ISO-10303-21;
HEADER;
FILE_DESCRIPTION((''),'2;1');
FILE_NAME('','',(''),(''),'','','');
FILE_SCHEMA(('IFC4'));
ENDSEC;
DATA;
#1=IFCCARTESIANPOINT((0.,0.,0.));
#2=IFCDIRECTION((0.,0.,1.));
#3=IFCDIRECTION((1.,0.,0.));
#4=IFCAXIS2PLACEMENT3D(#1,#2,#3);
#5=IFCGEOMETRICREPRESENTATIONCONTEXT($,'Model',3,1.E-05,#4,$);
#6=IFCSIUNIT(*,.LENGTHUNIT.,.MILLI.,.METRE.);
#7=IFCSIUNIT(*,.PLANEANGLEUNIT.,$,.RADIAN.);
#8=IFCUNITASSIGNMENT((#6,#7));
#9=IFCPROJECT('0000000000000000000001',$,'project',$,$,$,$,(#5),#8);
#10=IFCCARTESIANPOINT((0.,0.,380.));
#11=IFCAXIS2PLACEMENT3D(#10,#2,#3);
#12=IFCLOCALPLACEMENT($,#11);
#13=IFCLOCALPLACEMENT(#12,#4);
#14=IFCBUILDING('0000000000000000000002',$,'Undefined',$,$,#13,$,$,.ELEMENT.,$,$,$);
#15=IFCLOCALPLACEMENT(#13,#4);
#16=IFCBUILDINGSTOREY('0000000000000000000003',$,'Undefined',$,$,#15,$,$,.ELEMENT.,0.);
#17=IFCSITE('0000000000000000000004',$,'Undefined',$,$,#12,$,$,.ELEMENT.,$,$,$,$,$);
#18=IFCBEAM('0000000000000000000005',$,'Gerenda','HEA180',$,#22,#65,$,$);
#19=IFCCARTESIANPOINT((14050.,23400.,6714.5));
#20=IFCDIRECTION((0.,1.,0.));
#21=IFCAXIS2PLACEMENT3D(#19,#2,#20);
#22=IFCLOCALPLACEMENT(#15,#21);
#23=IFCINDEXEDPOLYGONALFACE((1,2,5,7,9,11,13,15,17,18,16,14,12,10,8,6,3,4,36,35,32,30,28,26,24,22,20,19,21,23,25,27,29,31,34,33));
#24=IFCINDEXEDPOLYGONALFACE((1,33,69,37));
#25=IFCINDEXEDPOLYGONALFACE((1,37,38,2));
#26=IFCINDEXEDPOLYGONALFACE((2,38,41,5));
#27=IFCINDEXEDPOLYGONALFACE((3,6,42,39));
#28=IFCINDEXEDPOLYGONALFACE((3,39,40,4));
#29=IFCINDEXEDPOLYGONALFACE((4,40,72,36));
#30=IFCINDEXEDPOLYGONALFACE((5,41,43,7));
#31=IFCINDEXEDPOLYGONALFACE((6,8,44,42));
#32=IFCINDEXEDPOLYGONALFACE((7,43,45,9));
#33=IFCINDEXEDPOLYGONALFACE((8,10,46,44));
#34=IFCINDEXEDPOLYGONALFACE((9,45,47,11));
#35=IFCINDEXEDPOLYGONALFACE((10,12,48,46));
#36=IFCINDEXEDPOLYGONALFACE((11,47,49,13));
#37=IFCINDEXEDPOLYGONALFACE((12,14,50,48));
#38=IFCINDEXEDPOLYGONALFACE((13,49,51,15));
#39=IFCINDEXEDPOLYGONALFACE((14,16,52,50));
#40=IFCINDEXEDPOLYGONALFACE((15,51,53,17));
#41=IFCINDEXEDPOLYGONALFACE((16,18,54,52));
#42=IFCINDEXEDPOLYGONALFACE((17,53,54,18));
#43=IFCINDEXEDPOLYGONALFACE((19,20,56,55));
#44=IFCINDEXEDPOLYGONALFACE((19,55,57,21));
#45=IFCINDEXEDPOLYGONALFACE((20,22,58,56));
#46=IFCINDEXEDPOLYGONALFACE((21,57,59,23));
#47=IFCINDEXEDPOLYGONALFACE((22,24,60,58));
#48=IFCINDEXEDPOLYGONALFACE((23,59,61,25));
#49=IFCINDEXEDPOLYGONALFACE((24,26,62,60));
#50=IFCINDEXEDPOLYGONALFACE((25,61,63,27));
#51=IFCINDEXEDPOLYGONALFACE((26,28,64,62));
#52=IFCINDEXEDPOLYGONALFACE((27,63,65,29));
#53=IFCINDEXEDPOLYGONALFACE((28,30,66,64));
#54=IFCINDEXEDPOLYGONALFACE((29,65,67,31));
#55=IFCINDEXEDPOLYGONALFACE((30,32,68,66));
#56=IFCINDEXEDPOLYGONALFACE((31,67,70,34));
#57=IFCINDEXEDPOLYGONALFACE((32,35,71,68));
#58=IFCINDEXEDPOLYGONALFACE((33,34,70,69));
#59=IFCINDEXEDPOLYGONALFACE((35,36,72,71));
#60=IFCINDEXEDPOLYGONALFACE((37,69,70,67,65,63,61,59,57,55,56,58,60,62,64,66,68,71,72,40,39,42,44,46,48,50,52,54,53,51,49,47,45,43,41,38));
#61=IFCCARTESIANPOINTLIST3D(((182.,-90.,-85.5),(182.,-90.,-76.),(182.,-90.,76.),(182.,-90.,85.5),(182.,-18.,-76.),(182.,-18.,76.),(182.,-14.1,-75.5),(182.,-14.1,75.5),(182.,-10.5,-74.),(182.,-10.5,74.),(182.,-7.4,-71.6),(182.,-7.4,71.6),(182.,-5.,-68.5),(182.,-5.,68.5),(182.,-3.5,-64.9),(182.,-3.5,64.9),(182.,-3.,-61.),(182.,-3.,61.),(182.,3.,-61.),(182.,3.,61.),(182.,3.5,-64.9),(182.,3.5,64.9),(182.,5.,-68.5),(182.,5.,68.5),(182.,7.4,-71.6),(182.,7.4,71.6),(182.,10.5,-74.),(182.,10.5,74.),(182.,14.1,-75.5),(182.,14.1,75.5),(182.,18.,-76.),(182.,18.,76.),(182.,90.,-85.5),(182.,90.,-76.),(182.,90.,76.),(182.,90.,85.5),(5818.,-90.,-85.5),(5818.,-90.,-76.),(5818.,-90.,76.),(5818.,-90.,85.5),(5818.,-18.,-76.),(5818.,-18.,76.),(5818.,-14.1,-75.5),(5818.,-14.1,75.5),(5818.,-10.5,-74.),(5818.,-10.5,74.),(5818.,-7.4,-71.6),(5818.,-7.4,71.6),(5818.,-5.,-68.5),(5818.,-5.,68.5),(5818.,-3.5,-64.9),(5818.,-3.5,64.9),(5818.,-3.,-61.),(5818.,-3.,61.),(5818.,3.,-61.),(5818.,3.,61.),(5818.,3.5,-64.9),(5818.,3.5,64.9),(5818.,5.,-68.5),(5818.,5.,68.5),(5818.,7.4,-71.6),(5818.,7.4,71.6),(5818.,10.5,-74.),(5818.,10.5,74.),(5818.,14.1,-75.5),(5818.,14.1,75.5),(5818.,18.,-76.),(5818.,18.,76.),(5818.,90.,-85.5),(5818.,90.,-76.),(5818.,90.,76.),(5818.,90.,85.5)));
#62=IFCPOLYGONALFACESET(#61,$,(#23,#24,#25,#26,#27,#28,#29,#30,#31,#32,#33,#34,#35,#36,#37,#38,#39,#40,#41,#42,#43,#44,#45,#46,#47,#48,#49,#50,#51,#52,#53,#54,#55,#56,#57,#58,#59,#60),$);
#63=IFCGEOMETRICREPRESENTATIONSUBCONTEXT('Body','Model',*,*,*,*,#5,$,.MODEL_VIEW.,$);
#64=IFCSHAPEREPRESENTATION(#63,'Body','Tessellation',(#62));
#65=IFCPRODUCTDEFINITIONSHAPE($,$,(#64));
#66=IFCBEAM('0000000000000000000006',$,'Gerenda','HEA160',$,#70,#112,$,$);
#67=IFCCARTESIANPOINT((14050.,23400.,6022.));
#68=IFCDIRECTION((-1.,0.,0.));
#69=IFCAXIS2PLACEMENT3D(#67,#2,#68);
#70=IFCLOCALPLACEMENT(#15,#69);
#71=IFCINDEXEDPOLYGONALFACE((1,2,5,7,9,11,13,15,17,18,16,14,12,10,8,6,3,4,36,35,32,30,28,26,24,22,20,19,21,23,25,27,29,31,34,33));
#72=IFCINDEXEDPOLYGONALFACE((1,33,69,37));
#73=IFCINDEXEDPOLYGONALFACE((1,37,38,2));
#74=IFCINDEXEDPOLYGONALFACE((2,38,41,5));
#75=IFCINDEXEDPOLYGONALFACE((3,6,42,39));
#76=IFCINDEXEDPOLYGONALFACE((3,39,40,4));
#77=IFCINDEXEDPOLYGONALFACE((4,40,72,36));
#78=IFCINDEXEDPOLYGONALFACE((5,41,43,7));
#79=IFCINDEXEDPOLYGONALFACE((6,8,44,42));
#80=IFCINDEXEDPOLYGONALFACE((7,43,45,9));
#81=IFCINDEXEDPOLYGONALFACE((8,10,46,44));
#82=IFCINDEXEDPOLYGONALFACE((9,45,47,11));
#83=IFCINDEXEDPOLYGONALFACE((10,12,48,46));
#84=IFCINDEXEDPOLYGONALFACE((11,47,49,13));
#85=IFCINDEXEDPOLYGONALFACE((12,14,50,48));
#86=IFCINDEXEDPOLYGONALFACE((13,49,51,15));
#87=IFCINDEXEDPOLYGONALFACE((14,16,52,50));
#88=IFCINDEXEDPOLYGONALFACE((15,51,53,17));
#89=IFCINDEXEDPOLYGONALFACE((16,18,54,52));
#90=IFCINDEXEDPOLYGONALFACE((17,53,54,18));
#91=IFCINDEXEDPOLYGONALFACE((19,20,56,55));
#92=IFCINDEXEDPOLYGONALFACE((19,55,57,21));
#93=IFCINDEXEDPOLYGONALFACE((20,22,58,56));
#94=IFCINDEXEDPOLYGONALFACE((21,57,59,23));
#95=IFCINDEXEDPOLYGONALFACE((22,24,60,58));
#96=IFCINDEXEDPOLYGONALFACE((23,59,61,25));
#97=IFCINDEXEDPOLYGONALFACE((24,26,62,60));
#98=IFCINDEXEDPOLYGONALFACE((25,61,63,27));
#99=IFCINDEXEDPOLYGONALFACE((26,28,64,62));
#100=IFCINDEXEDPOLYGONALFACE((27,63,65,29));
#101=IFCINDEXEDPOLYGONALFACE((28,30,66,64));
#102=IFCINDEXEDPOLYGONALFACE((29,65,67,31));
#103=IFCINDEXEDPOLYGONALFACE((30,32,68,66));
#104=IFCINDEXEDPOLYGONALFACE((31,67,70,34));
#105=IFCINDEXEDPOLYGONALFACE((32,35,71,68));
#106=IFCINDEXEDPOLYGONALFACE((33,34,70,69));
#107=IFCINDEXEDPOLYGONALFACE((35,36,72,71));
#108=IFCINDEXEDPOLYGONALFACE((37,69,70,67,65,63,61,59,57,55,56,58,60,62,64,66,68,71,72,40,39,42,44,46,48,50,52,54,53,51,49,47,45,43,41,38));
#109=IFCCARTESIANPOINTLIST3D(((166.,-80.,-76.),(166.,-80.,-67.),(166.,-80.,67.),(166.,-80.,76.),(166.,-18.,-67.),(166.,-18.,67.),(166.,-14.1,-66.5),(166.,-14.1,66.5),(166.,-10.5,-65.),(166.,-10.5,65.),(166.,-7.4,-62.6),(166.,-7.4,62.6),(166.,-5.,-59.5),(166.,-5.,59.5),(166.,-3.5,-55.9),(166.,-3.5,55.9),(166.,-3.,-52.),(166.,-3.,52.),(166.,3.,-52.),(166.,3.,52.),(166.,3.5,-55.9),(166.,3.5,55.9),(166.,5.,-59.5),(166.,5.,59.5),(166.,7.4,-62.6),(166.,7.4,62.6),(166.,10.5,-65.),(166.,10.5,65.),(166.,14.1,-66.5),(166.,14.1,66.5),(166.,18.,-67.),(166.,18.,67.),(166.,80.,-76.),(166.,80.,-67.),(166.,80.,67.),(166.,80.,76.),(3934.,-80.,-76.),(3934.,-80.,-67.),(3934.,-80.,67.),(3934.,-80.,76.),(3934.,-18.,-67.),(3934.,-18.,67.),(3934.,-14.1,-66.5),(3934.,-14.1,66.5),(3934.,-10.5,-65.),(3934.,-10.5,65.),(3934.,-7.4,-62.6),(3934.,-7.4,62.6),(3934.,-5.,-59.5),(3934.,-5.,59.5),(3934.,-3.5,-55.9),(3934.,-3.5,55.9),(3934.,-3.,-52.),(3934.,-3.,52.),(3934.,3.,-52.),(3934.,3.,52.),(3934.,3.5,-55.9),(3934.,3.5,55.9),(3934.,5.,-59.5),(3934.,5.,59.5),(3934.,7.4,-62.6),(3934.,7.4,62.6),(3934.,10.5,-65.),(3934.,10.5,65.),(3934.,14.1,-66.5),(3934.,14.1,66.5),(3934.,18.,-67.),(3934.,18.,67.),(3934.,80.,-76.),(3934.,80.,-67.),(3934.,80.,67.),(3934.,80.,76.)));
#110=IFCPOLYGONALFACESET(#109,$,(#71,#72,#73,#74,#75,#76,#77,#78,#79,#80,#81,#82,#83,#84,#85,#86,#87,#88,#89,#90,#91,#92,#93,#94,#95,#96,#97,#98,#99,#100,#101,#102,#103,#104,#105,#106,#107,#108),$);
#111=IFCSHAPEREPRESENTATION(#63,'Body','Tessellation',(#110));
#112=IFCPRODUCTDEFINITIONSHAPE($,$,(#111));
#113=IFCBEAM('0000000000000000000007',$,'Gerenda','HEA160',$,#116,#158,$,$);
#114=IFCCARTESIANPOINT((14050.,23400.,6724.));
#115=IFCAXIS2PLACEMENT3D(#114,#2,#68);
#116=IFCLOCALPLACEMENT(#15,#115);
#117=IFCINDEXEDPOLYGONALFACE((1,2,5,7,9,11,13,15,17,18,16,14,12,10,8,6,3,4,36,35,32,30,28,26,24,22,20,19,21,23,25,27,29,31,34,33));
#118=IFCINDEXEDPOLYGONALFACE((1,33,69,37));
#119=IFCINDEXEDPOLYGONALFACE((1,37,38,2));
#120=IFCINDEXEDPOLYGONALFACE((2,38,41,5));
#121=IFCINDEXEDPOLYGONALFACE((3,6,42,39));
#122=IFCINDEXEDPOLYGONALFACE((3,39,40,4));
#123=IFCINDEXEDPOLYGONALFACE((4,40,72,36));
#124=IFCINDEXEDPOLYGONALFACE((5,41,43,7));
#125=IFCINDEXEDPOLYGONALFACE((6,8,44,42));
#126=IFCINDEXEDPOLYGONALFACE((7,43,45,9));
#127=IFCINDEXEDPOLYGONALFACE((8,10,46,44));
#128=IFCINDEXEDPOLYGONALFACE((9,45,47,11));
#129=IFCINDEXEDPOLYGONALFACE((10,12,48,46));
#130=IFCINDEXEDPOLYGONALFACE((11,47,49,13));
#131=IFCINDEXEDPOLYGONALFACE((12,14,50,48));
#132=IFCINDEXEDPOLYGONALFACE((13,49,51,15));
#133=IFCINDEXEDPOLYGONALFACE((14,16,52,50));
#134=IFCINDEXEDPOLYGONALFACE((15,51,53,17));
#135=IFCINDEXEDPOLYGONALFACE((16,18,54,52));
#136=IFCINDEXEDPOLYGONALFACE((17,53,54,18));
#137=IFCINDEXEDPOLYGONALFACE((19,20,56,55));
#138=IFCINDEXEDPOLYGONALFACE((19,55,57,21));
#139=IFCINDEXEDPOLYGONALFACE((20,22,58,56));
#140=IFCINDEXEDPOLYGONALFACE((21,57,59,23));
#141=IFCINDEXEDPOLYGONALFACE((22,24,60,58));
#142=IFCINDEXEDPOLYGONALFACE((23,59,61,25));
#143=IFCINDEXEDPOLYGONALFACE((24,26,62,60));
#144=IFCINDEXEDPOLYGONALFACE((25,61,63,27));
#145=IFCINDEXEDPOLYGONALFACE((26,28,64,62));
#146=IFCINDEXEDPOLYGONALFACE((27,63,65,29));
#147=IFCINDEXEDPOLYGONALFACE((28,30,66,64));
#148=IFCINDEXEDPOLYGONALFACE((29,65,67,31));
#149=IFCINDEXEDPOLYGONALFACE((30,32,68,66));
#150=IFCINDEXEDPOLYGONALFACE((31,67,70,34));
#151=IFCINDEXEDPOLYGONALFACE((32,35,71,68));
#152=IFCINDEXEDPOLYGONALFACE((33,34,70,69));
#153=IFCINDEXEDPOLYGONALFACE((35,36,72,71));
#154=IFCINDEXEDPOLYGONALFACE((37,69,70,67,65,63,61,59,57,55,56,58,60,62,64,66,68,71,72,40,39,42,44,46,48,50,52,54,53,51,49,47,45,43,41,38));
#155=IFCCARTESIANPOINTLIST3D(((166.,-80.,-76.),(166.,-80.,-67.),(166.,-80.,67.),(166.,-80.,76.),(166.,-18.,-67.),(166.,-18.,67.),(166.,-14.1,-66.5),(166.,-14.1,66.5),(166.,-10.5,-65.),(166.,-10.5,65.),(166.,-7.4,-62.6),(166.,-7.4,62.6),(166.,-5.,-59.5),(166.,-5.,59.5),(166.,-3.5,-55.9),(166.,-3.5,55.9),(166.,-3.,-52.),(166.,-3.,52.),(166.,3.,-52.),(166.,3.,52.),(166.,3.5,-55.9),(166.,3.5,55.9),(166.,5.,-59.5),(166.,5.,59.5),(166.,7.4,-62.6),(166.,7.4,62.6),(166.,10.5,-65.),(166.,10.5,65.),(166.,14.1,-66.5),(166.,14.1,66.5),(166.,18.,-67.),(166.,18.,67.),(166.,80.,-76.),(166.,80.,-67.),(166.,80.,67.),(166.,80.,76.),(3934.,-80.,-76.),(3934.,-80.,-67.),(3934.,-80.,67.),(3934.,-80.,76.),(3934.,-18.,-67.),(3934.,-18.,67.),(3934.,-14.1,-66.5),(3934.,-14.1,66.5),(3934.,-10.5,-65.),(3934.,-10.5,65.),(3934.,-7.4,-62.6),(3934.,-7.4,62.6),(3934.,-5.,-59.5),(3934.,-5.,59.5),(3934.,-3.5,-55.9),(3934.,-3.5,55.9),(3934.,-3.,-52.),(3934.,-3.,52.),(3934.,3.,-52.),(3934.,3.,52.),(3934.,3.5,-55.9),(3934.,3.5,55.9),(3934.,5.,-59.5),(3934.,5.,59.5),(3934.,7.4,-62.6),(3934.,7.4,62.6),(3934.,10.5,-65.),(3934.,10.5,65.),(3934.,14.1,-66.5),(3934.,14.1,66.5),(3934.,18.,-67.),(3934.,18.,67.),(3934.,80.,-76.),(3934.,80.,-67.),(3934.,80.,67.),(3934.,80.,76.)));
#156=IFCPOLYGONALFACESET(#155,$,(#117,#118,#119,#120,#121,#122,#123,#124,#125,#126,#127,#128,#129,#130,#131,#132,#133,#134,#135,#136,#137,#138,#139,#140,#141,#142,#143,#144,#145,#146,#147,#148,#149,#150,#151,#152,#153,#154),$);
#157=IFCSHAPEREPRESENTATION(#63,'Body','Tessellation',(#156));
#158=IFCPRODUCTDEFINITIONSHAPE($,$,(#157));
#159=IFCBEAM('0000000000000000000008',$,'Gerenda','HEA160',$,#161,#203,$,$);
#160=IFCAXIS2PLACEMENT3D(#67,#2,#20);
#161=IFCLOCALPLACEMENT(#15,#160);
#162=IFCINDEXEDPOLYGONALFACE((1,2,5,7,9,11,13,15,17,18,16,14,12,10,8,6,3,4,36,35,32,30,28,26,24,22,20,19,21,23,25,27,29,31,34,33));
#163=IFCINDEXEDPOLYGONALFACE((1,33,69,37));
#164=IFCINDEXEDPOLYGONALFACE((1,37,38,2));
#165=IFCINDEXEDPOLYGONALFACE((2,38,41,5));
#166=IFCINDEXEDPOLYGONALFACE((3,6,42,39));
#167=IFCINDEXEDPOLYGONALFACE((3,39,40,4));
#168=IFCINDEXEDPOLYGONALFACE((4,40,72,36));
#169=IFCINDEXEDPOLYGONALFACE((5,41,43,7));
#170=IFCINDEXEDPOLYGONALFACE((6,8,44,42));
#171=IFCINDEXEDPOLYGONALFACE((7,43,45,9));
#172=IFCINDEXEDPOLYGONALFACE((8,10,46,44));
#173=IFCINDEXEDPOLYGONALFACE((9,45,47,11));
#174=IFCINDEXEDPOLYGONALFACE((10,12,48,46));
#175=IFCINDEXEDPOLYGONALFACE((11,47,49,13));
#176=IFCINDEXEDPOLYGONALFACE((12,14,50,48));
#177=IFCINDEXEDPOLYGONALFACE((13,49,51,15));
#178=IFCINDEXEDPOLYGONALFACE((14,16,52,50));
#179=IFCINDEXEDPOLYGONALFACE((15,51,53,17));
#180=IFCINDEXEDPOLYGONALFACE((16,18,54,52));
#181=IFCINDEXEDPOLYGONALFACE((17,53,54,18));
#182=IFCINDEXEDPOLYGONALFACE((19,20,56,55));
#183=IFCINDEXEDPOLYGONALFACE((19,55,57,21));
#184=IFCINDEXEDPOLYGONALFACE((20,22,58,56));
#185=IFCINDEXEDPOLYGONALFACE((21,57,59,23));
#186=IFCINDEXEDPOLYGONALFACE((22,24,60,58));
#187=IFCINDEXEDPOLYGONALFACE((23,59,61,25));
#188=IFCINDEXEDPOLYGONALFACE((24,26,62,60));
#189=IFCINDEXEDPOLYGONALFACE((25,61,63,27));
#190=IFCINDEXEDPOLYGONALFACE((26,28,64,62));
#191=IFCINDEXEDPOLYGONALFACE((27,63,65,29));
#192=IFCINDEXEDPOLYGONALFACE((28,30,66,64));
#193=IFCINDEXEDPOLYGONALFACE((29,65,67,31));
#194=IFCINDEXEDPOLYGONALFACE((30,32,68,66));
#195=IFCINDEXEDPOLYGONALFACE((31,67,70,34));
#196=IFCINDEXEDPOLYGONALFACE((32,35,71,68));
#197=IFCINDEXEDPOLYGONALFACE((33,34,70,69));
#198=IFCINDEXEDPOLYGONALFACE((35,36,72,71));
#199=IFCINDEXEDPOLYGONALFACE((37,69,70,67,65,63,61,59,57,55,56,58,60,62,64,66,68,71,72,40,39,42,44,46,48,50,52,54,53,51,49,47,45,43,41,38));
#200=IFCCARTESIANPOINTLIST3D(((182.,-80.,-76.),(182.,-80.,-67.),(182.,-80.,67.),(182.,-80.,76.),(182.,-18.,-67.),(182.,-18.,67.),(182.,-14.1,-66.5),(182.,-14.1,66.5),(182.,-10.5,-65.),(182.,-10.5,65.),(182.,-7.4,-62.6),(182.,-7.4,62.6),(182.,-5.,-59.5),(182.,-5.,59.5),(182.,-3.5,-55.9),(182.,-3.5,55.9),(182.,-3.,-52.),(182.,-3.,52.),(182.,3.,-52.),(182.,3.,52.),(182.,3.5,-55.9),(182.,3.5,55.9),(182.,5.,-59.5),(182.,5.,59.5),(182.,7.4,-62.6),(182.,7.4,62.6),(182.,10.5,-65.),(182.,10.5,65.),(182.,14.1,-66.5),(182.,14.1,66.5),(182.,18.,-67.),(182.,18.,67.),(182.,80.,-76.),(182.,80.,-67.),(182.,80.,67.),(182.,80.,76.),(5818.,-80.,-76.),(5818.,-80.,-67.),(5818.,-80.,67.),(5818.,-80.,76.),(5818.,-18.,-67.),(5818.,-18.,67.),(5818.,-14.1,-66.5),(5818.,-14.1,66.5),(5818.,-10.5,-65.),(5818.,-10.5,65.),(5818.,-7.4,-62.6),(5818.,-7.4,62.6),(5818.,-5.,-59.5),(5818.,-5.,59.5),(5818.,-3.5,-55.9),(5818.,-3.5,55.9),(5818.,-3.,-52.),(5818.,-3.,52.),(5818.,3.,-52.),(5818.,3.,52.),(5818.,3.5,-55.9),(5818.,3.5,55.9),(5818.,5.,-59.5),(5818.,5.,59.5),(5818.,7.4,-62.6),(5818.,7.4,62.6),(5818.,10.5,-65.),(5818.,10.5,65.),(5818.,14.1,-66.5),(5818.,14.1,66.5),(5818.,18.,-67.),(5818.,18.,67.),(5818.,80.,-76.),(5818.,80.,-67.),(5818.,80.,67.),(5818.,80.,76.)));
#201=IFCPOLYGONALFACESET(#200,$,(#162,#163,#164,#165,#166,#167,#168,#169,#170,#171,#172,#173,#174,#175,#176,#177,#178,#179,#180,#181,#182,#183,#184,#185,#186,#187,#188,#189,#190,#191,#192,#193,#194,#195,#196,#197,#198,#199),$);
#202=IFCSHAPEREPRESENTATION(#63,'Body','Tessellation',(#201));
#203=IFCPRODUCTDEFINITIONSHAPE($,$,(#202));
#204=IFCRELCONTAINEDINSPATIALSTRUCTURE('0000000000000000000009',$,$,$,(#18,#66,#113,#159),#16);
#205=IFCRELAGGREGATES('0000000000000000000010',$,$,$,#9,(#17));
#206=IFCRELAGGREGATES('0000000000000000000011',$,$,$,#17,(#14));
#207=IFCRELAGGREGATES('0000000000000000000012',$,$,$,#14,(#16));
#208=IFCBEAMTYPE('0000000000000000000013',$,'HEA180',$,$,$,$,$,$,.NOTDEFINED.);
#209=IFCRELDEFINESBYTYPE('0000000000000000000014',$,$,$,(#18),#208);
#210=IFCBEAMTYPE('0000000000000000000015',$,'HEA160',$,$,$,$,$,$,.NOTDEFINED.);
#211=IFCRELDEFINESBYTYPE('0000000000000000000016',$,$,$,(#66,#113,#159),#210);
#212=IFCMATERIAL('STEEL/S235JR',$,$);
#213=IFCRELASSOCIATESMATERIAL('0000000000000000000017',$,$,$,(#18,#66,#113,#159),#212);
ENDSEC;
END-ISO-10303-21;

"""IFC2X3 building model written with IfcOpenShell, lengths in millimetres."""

from ifc_helpers import new_model, si_unit, frame, origin_with_axes, origin_2d_with_axis, place, context, subcontext, project, spatial, i_section, extrude, clip, halfspace, material, type_object, element, save


model = new_model("IFC2X3")

# Units and contexts
model_context = context("Model", 3, precision=1e-05, world=origin_with_axes())
body_context = subcontext(model_context, "Body", "Model", "MODEL_VIEW")
ifc_project = project(units=[si_unit("LENGTHUNIT", "METRE", prefix="MILLI"), si_unit("PLANEANGLEUNIT", "RADIAN")], contexts=[model_context])

# Site, building, storey
site_placement = place(None, frame((0.0, 0.0, 380.0), z_axis=(0.0, 0.0, 1.0), x_axis=(1.0, 0.0, 0.0)))
site = spatial("IfcSite", under=ifc_project, at=site_placement, Name="Undefined", CompositionType="ELEMENT")
building_placement = place(site_placement, origin_with_axes())
building = spatial("IfcBuilding", under=site, at=building_placement, Name="Undefined", CompositionType="ELEMENT")
storey_placement = place(building_placement, origin_with_axes())
storey = spatial("IfcBuildingStorey", under=building, at=storey_placement, Name="Undefined", CompositionType="ELEMENT", Elevation=0.0)

# Shared definitions
ifc_material_1 = material(Name="STEEL/S235JR")

# Beams
beam_type_1 = type_object("IfcBeamType", Name="HEA180", PredefinedType="NOTDEFINED")
beam_1_placement = place(storey_placement, frame((14050.0, 23400.0, 6714.5), z_axis=(0.0, 0.0, 1.0), x_axis=(0.0, 1.0, 0.0)))
element("IfcBeam", 1, at=beam_1_placement, inside=storey, type_object=beam_type_1, material=ifc_material_1, Name="Gerenda", Description="HEA180", context=body_context, shape_type="Clipping", body=[
    clip(clip(extrude(i_section(OverallWidth=180.0, OverallDepth=171.0, WebThickness=6.0, FlangeThickness=9.5, FilletRadius=15.0, at=origin_2d_with_axis()), frame((6000.0, 0.0, 0.0), z_axis=(-1.0, 0.0, 0.0), x_axis=(0.0, -1.0, 0.0)), (0.0, 0.0, 1.0), 6000.0), halfspace(frame((5818.0, 0.0, -85.5), z_axis=(-1.0, 0.0, 0.0), x_axis=(0.0, 1.0, 0.0)), True)), halfspace(frame((182.0, 0.0, 85.5), z_axis=(1.0, 0.0, 0.0), x_axis=(0.0, 1.0, 0.0)), True)),
])
beam_type_2 = type_object("IfcBeamType", Name="HEA160", PredefinedType="NOTDEFINED")
for number, where, z_axis, x_axis, name in (
    (2, (14050.0, 23400.0, 6022.0), (0.0, 0.0, 1.0), (-1.0, 0.0, 0.0), "Gerenda"),
    (3, (14050.0, 23400.0, 6724.0), (0.0, 0.0, 1.0), (-1.0, 0.0, 0.0), "Gerenda"),
):
    element("IfcBeam", number, at=place(storey_placement, frame(where, z_axis=z_axis, x_axis=x_axis)), inside=storey, type_object=beam_type_2, material=ifc_material_1, Name=name, Description="HEA160", context=body_context, shape_type="Clipping", body=[
        clip(clip(extrude(i_section(OverallWidth=160.0, OverallDepth=152.0, WebThickness=6.0, FlangeThickness=9.0, FilletRadius=15.0, at=origin_2d_with_axis()), frame((4100.0, 0.0, 0.0), z_axis=(-1.0, 0.0, 0.0), x_axis=(0.0, -1.0, 0.0)), (0.0, 0.0, 1.0), 4100.0), halfspace(frame((3934.0, 0.0, -76.0), z_axis=(-1.0, 0.0, 0.0), x_axis=(0.0, 1.0, 0.0)), True)), halfspace(frame((166.0, 0.0, -76.0), z_axis=(1.0, 0.0, 0.0), x_axis=(0.0, -1.0, 0.0)), True)),
    ])
beam_2_placement = place(storey_placement, frame((14050.0, 23400.0, 6022.0), z_axis=(0.0, 0.0, 1.0), x_axis=(0.0, 1.0, 0.0)))
element("IfcBeam", 4, at=beam_2_placement, inside=storey, type_object=beam_type_2, material=ifc_material_1, Name="Gerenda", Description="HEA160", context=body_context, shape_type="Clipping", body=[
    clip(clip(extrude(i_section(OverallWidth=160.0, OverallDepth=152.0, WebThickness=6.0, FlangeThickness=9.0, FilletRadius=15.0, at=origin_2d_with_axis()), frame((6000.0, 0.0, 0.0), z_axis=(-1.0, 0.0, 0.0), x_axis=(0.0, -1.0, 0.0)), (0.0, 0.0, 1.0), 6000.0), halfspace(frame((5818.0, 0.0, -76.0), z_axis=(-1.0, 0.0, 0.0), x_axis=(0.0, 1.0, 0.0)), True)), halfspace(frame((182.0, 0.0, 76.0), z_axis=(1.0, 0.0, 0.0), x_axis=(0.0, 1.0, 0.0)), True)),
])

save(model, "model.ifc")
